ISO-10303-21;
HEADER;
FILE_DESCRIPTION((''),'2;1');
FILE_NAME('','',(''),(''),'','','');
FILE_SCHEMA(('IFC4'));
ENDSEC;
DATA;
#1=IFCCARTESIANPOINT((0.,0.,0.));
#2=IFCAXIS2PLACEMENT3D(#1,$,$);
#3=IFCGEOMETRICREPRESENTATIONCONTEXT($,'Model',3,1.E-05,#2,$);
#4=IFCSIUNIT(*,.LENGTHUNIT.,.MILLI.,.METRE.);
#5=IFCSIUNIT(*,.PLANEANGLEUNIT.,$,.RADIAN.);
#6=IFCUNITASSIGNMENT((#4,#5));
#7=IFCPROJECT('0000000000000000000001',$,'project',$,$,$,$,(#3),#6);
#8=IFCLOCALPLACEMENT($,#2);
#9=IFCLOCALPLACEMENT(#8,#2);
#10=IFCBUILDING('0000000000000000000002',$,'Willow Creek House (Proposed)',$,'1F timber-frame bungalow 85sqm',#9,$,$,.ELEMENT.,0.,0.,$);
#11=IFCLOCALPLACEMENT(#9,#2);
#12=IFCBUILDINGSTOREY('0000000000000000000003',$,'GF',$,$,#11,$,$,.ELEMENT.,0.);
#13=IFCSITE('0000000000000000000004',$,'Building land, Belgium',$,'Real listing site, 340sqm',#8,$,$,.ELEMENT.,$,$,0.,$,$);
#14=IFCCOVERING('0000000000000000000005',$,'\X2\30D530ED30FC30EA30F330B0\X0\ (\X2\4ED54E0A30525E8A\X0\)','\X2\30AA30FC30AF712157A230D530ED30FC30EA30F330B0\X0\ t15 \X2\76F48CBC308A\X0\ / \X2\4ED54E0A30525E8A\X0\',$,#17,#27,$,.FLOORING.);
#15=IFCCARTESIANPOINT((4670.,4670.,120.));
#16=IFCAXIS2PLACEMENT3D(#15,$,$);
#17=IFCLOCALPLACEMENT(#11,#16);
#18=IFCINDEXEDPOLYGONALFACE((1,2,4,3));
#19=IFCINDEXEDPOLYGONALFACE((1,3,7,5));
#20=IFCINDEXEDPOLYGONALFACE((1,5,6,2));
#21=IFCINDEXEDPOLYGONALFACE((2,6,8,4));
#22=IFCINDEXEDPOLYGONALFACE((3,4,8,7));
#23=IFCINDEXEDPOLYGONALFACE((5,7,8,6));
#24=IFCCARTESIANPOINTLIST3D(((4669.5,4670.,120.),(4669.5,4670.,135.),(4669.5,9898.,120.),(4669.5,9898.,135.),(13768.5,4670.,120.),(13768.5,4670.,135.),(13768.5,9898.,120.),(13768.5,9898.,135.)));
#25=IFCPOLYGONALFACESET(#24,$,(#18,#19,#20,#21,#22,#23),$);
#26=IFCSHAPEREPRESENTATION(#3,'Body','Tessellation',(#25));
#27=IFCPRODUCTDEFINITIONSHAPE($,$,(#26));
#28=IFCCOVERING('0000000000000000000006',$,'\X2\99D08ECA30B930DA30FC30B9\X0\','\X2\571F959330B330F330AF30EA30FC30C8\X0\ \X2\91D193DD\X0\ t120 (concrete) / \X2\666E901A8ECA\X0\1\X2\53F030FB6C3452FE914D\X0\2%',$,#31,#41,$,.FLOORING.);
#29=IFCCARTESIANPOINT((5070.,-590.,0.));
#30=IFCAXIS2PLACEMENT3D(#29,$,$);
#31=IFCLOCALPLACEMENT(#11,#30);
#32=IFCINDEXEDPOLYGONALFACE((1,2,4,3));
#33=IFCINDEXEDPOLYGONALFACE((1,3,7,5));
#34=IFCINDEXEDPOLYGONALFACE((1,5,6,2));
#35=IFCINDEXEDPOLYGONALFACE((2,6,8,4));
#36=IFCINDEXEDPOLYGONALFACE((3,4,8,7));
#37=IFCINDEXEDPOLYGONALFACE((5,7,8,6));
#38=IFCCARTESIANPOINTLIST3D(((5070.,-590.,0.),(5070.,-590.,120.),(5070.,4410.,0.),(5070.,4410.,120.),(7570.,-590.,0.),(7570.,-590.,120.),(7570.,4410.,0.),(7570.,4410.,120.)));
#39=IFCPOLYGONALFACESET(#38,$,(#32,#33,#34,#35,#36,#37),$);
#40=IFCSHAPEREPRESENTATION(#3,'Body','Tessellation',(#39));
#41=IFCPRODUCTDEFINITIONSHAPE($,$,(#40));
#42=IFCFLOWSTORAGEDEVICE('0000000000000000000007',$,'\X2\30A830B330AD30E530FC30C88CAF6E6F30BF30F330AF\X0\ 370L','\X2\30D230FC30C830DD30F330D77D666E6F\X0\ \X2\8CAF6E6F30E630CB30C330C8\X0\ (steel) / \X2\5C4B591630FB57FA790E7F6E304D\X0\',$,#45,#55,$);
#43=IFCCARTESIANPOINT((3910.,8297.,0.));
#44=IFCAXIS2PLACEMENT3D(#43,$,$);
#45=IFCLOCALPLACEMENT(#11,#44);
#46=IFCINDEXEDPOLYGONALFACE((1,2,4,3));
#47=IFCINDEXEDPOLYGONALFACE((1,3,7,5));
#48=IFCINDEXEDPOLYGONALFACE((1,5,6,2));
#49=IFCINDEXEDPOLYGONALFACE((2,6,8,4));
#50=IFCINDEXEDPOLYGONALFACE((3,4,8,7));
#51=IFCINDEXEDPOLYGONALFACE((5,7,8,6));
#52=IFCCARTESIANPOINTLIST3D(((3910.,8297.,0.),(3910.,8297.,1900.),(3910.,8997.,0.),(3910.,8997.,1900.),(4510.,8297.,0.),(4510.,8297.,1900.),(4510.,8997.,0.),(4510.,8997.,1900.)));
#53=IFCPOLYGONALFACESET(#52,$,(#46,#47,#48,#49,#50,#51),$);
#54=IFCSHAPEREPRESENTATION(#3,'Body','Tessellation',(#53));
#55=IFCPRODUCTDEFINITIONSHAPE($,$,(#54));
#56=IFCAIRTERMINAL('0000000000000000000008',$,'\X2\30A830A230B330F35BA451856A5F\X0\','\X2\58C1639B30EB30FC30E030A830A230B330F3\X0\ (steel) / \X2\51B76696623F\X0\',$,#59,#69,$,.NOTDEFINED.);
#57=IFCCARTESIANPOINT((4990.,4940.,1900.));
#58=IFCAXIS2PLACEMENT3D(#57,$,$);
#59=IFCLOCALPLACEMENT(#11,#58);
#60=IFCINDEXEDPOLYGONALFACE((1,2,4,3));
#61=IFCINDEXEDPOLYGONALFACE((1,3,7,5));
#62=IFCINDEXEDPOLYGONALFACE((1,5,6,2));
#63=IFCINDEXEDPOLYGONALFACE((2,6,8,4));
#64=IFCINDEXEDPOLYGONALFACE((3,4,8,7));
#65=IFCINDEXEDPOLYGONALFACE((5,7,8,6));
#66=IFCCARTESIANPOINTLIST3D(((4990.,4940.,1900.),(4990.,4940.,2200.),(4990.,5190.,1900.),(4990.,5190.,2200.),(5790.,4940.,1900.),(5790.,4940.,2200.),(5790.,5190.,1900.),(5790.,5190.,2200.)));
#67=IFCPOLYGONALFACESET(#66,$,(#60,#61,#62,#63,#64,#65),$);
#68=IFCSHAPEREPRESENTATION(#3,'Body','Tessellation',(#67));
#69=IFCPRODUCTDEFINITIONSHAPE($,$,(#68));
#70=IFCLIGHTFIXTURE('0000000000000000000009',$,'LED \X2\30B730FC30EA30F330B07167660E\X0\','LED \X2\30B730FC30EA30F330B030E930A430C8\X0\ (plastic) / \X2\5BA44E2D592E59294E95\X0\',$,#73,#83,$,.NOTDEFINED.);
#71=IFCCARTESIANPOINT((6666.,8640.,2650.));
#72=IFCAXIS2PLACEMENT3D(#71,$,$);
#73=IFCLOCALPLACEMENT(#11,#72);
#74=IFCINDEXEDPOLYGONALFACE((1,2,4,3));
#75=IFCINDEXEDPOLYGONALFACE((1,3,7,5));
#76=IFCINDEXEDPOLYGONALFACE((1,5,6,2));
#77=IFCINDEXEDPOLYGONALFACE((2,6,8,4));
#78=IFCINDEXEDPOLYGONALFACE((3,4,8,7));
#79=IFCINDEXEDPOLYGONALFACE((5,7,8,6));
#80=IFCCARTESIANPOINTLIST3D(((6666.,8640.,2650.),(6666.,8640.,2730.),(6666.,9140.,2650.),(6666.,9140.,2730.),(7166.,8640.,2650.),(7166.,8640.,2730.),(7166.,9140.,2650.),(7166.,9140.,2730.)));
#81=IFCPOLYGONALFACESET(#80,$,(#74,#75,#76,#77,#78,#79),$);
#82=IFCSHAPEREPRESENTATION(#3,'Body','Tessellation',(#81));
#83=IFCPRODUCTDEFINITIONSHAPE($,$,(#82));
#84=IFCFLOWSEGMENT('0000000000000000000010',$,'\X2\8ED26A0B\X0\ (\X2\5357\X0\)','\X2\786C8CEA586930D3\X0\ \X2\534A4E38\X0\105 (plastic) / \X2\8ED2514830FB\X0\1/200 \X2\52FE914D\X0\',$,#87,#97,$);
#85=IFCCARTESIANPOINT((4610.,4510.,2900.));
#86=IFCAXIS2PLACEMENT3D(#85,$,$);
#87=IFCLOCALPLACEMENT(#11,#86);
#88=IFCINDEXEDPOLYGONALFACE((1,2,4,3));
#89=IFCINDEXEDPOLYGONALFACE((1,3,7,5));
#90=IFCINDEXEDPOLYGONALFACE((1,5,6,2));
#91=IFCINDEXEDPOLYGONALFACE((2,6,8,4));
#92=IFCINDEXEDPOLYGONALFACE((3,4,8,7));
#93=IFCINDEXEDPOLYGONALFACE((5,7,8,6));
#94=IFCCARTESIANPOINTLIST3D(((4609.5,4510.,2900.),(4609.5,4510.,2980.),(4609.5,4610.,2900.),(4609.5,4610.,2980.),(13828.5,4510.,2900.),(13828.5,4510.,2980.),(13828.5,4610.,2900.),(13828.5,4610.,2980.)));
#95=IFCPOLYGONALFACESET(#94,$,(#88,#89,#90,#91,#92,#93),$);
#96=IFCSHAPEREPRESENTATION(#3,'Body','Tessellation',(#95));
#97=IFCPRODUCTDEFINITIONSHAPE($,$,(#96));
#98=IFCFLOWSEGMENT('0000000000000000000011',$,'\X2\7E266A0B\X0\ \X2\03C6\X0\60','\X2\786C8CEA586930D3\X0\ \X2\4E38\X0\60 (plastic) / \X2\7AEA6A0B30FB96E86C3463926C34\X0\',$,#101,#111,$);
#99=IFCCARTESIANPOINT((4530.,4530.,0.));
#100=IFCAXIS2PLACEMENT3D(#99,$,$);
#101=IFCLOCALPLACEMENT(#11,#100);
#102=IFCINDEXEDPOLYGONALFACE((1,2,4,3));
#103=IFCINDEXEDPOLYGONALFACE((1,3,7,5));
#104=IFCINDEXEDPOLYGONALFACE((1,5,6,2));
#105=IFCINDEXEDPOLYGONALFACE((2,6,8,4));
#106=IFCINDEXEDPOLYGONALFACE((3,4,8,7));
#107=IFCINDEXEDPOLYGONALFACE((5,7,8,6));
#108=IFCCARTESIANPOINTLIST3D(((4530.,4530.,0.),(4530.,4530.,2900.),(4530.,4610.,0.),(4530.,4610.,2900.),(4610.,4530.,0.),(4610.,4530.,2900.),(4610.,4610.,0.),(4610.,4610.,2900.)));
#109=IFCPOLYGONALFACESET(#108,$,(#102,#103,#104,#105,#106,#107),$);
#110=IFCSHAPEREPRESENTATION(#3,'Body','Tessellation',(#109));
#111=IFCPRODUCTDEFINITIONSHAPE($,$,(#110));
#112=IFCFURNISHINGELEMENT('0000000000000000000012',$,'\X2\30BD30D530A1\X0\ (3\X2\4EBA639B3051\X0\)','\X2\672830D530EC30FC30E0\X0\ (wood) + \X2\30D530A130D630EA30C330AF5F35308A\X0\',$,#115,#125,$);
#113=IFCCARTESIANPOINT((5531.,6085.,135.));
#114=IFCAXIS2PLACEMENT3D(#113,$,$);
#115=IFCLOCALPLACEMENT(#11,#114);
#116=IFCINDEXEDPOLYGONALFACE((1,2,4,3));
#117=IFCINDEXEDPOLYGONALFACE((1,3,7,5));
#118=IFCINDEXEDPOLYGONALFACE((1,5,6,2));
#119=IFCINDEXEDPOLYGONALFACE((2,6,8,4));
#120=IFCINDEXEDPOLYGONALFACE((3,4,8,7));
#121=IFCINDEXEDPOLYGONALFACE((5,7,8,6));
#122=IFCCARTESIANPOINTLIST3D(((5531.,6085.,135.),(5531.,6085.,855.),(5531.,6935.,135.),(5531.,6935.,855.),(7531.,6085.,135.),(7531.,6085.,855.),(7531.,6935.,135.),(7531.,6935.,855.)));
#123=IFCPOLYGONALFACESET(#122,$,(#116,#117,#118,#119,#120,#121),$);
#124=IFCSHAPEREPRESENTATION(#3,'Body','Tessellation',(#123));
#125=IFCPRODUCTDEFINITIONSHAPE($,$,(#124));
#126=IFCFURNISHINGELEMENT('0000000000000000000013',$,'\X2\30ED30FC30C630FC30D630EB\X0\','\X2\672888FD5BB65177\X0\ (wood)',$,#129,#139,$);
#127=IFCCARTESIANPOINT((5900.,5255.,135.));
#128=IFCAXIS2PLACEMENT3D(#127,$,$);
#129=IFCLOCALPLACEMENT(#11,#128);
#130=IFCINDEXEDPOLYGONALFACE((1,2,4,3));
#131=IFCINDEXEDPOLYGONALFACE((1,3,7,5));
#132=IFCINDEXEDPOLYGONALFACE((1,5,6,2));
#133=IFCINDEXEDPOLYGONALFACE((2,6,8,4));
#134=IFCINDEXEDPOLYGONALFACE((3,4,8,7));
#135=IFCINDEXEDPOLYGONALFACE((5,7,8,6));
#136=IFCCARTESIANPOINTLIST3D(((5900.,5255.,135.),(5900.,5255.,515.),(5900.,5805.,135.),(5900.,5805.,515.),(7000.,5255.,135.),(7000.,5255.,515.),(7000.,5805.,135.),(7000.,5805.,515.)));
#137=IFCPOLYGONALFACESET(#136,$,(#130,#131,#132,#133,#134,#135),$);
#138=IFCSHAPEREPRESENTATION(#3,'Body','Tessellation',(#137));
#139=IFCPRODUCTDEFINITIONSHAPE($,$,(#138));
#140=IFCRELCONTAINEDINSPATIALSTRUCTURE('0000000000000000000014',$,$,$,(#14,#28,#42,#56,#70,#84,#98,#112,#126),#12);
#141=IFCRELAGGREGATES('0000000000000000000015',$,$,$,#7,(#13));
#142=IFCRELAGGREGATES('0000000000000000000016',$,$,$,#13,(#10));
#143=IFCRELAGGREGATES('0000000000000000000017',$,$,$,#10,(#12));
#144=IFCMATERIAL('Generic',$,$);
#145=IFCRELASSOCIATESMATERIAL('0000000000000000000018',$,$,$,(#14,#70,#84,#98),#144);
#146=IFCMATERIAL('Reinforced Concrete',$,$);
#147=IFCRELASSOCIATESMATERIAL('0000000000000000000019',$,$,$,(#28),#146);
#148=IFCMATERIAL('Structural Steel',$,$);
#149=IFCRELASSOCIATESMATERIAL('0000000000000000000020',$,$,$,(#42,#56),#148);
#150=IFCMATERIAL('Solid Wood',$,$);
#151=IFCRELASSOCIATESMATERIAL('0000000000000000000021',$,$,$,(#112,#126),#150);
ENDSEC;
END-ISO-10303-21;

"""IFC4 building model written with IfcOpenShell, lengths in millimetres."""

from ifc_helpers import new_model, si_unit, frame, frame_2d, origin, place, context, project, spatial, rectangle, extrude, material, element, save


model = new_model("IFC4")

# Units and contexts
model_context = context("Model", 3, precision=1e-05, world=origin())
ifc_project = project(units=[si_unit("LENGTHUNIT", "METRE", prefix="MILLI"), si_unit("PLANEANGLEUNIT", "RADIAN")], contexts=[model_context])

# Site, building, storey
site_placement = place(None, origin())
site = spatial("IfcSite", under=ifc_project, at=site_placement, Name="Building land, Belgium", ObjectType="Real listing site, 340sqm", CompositionType="ELEMENT", RefElevation=0.0)
building_placement = place(site_placement, origin())
building = spatial("IfcBuilding", under=site, at=building_placement, Name="Willow Creek House (Proposed)", ObjectType="1F timber-frame bungalow 85sqm", CompositionType="ELEMENT", ElevationOfRefHeight=0.0, ElevationOfTerrain=0.0)
storey_placement = place(building_placement, origin())
storey = spatial("IfcBuildingStorey", under=building, at=storey_placement, Name="GF", CompositionType="ELEMENT", Elevation=0.0)

# Shared definitions
ifc_material_1 = material(Name="Solid Wood")

# Shared definitions
ifc_material_2 = material(Name="Reinforced Concrete")

# Shared definitions
ifc_material_3 = material(Name="Structural Steel")

# Coverings
ifc_material_4 = material(Name="Generic")
covering_1_placement = place(storey_placement, frame((4670.0, 4670.0, 120.0)))
element("IfcCovering", 1, at=covering_1_placement, inside=storey, material=ifc_material_4, Name="フローリング (仕上げ床)", Description="オーク無垢フローリング t15 直貼り / 仕上げ床", PredefinedType="FLOORING", context=model_context, shape_type="SweptSolid", body=[
    extrude(rectangle(XDim=9099.0, YDim=5228.0, at=frame_2d((4549.0, 2614.0))), frame((4670.0, 4670.0, 120.0)), (0.0, 0.0, 1.0), 15.0),
])
covering_2_placement = place(storey_placement, frame((5070.0, -590.0, 0.0)))
element("IfcCovering", 2, at=covering_2_placement, inside=storey, material=ifc_material_2, Name="駐車スペース", Description="土間コンクリート 金鏝 t120 (concrete) / 普通車1台・水勾配2%", PredefinedType="FLOORING", context=model_context, shape_type="SweptSolid", body=[
    extrude(rectangle(XDim=2500.0, YDim=5000.0, at=frame_2d((1250.0, 2500.0))), frame((5070.0, -590.0, 0.0)), (0.0, 0.0, 1.0), 120.0),
])

# Flow storage device
flow_storage_device_placement = place(storey_placement, frame((3910.0, 8297.0, 0.0)))
element("IfcFlowStorageDevice", 3, at=flow_storage_device_placement, inside=storey, material=ifc_material_3, Name="エコキュート貯湯タンク 370L", Description="ヒートポンプ給湯 貯湯ユニット (steel) / 屋外・基礎置き", context=model_context, shape_type="SweptSolid", body=[
    extrude(rectangle(XDim=600.0, YDim=700.0, at=frame_2d((300.0, 350.0))), frame((3910.0, 8297.0, 0.0)), (0.0, 0.0, 1.0), 1900.0),
])

# Air terminal
air_terminal_placement = place(storey_placement, frame((4990.0, 4940.0, 1900.0)))
element("IfcAirTerminal", 4, at=air_terminal_placement, inside=storey, material=ifc_material_3, Name="エアコン室内機", Description="壁掛ルームエアコン (steel) / 冷暖房", PredefinedType="NOTDEFINED", context=model_context, shape_type="SweptSolid", body=[
    extrude(rectangle(XDim=800.0, YDim=250.0, at=frame_2d((400.0, 125.0))), frame((4990.0, 4940.0, 1900.0)), (0.0, 0.0, 1.0), 300.0),
])

# Light fixture
light_fixture_placement = place(storey_placement, frame((6666.0, 8640.0, 2650.0)))
element("IfcLightFixture", 5, at=light_fixture_placement, inside=storey, material=ifc_material_4, Name="LED シーリング照明", Description="LED シーリングライト (plastic) / 室中央天井", PredefinedType="NOTDEFINED", context=model_context, shape_type="SweptSolid", body=[
    extrude(rectangle(XDim=500.0, YDim=500.0, at=frame_2d((250.0, 250.0))), frame((6666.0, 8640.0, 2650.0)), (0.0, 0.0, 1.0), 80.0),
])

# Flow segments
flow_segment_1_placement = place(storey_placement, frame((4610.0, 4510.0, 2900.0)))
element("IfcFlowSegment", 6, at=flow_segment_1_placement, inside=storey, material=ifc_material_4, Name="軒樋 (南)", Description="硬質塩ビ 半丸105 (plastic) / 軒先・1/200 勾配", context=model_context, shape_type="SweptSolid", body=[
    extrude(rectangle(XDim=9219.0, YDim=100.0, at=frame_2d((4609.0, 50.0))), frame((4610.0, 4510.0, 2900.0)), (0.0, 0.0, 1.0), 80.0),
])
flow_segment_2_placement = place(storey_placement, frame((4530.0, 4530.0, 0.0)))
element("IfcFlowSegment", 7, at=flow_segment_2_placement, inside=storey, material=ifc_material_4, Name="縦樋 φ60", Description="硬質塩ビ 丸60 (plastic) / 竪樋・雨水排水", context=model_context, shape_type="SweptSolid", body=[
    extrude(rectangle(XDim=80.0, YDim=80.0, at=frame_2d((40.0, 40.0))), frame((4530.0, 4530.0, 0.0)), (0.0, 0.0, 1.0), 2900.0),
])

# Furnishing elements
furnishing_1_placement = place(storey_placement, frame((5531.0, 6085.0, 135.0)))
element("IfcFurnishingElement", 8, at=furnishing_1_placement, inside=storey, material=ifc_material_1, Name="ソファ (3人掛け)", Description="木フレーム (wood) + ファブリック張り", context=model_context, shape_type="SweptSolid", body=[
    extrude(rectangle(XDim=2000.0, YDim=850.0, at=frame_2d((1000.0, 425.0))), frame((5531.0, 6085.0, 135.0)), (0.0, 0.0, 1.0), 720.0),
])
furnishing_2_placement = place(storey_placement, frame((5900.0, 5255.0, 135.0)))
element("IfcFurnishingElement", 9, at=furnishing_2_placement, inside=storey, material=ifc_material_1, Name="ローテーブル", Description="木製家具 (wood)", context=model_context, shape_type="SweptSolid", body=[
    extrude(rectangle(XDim=1100.0, YDim=550.0, at=frame_2d((550.0, 275.0))), frame((5900.0, 5255.0, 135.0)), (0.0, 0.0, 1.0), 380.0),
])

save(model, "model.ifc")
